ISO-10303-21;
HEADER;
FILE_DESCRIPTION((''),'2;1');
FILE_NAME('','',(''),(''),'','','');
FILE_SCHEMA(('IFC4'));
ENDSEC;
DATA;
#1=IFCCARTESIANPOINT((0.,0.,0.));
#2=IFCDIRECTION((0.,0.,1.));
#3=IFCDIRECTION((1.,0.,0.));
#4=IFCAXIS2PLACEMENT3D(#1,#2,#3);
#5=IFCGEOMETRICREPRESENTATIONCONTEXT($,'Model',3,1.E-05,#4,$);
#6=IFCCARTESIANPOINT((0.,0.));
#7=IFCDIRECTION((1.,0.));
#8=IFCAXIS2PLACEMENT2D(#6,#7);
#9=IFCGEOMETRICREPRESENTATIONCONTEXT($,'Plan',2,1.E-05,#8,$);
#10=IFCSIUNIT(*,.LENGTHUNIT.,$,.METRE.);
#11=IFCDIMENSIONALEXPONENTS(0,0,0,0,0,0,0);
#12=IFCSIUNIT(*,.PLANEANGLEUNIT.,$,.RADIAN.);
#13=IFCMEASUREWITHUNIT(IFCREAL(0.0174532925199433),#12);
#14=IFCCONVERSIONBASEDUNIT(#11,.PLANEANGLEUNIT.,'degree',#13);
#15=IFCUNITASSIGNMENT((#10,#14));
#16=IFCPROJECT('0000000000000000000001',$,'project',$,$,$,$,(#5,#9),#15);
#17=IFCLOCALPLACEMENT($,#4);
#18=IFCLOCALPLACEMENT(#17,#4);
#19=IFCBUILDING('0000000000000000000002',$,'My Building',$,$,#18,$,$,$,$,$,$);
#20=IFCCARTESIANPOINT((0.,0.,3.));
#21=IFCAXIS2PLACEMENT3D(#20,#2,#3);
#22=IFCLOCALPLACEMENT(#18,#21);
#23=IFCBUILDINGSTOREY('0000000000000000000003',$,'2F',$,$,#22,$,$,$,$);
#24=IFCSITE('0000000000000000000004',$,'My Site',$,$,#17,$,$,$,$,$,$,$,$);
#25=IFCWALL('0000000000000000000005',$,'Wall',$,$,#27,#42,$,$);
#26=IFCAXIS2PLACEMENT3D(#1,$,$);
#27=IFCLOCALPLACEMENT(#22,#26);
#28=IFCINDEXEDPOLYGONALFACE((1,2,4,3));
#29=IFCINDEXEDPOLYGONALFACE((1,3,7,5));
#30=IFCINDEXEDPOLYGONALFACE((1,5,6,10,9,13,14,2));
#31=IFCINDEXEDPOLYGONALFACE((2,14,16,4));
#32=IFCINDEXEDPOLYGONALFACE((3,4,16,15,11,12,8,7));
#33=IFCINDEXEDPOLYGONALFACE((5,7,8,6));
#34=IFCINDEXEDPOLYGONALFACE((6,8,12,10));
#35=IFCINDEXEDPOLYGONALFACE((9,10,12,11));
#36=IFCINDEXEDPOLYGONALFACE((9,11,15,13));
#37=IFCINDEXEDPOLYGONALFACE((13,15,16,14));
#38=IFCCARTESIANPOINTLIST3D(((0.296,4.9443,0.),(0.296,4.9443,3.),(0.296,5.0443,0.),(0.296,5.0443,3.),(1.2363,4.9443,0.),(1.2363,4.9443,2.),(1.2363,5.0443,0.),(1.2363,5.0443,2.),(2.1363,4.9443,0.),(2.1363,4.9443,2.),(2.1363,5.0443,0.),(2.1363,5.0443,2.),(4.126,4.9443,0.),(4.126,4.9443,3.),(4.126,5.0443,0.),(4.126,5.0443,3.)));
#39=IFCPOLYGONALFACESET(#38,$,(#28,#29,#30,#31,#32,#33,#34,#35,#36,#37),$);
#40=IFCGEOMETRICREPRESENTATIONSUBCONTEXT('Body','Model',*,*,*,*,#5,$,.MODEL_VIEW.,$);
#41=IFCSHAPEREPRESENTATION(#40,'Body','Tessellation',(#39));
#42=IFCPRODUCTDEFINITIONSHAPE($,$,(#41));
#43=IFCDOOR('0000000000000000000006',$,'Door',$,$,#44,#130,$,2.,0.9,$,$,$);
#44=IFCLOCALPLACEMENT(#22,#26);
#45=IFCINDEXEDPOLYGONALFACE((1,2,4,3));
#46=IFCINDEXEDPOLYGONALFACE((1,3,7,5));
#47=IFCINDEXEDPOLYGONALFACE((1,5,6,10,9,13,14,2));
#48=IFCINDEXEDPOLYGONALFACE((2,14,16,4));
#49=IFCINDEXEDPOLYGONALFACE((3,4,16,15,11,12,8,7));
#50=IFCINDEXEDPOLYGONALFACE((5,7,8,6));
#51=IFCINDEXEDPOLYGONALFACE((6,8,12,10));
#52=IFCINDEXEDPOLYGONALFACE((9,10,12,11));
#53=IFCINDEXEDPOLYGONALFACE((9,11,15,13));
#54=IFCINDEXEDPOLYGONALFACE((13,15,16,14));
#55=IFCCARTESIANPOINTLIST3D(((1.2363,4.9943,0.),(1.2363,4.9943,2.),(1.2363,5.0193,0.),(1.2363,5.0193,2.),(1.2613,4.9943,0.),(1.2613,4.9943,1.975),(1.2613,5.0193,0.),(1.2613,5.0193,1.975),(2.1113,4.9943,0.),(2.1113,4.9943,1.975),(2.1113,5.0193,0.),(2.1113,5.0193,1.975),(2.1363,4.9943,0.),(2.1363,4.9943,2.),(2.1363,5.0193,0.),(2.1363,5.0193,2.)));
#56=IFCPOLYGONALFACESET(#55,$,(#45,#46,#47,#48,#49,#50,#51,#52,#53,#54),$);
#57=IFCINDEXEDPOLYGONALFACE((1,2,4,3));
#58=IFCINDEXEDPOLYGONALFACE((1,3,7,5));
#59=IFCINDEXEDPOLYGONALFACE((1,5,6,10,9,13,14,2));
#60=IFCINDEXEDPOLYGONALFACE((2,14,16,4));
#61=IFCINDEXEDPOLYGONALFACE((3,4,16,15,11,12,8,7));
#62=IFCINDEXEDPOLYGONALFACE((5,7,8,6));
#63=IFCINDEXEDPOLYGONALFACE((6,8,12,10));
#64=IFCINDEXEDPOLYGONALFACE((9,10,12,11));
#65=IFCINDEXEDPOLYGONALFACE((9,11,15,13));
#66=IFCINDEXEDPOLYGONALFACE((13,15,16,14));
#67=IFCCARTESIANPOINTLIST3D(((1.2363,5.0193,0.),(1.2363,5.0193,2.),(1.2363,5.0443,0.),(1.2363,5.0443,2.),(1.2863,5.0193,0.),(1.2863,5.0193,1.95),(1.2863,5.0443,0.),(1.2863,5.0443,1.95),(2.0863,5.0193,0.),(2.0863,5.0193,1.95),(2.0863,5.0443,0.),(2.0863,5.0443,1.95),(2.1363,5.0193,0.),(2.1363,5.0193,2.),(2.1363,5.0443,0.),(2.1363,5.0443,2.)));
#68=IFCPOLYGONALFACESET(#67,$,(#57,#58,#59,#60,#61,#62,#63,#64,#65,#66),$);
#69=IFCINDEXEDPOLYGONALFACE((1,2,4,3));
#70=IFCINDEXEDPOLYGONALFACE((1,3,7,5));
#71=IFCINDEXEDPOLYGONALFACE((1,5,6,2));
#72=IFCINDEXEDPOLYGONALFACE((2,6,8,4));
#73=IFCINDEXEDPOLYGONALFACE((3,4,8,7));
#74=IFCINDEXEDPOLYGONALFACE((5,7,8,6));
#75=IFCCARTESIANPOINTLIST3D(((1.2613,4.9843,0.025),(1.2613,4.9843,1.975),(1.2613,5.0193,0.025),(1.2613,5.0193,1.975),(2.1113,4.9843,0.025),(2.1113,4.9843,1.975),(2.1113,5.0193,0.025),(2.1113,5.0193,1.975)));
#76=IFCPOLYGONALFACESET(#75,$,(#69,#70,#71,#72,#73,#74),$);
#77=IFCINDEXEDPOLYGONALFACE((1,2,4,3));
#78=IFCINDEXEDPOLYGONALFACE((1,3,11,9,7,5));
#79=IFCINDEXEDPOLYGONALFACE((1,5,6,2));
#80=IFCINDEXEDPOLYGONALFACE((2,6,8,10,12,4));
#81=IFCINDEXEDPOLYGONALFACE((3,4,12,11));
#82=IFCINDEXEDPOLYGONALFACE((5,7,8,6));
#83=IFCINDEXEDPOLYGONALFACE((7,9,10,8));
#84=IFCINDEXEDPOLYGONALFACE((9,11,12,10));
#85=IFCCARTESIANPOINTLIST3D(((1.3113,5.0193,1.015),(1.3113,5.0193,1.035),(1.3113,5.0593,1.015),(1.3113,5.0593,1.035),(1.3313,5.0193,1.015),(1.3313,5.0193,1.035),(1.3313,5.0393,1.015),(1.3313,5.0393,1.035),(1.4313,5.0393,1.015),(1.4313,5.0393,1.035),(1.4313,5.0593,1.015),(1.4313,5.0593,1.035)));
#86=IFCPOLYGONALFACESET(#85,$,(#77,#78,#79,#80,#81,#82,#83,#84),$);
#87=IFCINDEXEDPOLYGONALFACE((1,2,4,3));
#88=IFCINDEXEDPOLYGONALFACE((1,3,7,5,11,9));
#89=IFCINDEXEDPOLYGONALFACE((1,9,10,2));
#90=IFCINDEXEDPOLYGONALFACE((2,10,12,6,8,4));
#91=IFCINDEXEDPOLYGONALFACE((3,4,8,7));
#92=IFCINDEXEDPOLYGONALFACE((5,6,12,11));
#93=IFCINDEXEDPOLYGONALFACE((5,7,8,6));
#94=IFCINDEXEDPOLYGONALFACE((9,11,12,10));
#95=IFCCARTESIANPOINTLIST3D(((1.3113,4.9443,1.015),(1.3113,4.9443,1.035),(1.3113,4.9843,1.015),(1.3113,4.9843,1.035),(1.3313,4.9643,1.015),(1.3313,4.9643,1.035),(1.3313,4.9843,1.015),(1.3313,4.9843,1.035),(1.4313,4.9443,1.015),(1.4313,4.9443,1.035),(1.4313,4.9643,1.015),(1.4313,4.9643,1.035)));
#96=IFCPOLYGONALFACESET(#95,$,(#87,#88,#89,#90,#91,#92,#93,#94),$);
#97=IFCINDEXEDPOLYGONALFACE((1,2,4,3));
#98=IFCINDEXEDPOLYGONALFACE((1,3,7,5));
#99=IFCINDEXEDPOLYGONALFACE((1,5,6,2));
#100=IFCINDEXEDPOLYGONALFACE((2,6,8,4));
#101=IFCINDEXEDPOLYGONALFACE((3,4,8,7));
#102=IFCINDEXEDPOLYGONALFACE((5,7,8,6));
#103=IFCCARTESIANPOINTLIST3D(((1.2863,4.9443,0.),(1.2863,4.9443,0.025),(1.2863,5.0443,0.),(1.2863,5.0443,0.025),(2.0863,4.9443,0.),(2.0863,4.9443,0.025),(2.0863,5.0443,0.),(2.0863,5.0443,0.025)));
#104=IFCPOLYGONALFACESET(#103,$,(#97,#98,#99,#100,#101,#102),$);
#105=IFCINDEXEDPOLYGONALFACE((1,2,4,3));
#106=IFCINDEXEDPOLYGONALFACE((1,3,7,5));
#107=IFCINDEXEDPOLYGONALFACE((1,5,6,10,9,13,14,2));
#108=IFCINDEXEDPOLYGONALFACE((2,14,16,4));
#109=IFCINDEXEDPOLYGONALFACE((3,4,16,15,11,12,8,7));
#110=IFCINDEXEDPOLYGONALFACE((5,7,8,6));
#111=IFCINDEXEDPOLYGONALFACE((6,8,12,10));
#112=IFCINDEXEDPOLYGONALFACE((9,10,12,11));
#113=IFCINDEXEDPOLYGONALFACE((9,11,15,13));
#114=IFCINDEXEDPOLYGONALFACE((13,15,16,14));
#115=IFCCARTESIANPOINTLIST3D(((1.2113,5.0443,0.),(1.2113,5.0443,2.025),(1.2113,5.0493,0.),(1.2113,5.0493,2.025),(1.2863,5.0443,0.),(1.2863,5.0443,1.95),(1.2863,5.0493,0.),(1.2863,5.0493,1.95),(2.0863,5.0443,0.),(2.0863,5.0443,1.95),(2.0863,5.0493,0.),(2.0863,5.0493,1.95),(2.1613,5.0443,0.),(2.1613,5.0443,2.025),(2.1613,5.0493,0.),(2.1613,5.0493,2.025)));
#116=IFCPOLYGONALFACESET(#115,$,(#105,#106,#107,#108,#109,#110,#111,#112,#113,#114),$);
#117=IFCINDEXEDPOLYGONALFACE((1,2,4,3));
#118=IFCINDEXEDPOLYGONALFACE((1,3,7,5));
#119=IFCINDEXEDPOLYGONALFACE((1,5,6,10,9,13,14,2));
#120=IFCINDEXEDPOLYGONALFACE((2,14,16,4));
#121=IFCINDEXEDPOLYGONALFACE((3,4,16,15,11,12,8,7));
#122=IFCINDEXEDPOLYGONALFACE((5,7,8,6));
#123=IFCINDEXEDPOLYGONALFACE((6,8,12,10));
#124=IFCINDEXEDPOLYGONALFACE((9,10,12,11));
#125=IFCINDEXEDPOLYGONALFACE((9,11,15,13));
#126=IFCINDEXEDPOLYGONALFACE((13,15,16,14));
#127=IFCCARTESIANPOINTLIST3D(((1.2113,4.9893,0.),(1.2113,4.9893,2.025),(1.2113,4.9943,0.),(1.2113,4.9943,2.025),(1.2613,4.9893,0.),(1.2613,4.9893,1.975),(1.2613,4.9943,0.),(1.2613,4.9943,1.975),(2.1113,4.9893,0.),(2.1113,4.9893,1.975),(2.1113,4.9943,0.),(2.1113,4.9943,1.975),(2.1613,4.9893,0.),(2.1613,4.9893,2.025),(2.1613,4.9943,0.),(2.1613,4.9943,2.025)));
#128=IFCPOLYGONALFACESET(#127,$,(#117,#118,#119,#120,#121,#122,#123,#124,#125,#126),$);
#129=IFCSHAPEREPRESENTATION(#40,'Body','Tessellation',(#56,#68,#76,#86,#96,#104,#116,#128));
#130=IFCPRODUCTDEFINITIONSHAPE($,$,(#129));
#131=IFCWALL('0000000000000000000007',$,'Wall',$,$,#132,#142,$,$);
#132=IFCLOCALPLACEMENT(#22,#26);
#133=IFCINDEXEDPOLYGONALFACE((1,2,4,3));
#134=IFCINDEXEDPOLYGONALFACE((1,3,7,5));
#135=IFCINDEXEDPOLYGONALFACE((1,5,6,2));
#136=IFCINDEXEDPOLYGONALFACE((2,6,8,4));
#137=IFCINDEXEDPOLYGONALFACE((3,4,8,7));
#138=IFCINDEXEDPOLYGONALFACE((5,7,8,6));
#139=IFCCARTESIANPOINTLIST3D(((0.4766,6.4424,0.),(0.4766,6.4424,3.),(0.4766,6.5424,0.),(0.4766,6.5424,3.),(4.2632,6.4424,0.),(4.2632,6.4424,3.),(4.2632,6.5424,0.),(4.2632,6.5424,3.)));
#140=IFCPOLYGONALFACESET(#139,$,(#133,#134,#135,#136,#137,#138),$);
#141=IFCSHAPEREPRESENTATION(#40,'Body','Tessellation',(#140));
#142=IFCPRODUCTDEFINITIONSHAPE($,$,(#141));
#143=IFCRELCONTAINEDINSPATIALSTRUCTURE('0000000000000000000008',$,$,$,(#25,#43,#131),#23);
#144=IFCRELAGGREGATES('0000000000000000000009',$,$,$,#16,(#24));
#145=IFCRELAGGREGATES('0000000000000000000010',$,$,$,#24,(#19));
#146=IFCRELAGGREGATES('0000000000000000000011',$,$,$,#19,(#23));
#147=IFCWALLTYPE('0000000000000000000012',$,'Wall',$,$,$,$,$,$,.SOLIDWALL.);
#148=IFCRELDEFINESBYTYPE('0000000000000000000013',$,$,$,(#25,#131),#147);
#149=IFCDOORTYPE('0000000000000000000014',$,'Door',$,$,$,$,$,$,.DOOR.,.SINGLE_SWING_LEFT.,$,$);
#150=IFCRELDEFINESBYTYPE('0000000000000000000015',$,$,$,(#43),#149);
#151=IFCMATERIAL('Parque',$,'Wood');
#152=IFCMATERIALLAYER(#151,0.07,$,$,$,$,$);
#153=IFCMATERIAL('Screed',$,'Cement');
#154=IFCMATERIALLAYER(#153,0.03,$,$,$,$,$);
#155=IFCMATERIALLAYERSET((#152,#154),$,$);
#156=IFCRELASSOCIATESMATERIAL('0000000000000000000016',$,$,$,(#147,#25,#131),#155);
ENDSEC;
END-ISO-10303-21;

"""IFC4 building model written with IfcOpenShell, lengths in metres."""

from ifc_helpers import new_model, entity, si_unit, converted_unit, frame, origin_with_axes, origin_2d_with_axis, place, context, subcontext, project, spatial, line, indexed_curve, outline, extrude, shape, source, transform, mapped, material, layer, layer_set, layer_usage, type_object, type_shapes, element, fill, save


model = new_model("IFC4")

# Units and contexts
model_context = context("Model", 3, precision=1e-05, world=origin_with_axes())
plan_context = context("Plan", 2, precision=1e-05, world=origin_2d_with_axis())
body_context_1 = subcontext(model_context, "Body", "Model", "MODEL_VIEW")
body_context_2 = subcontext(plan_context, "Body", "Plan", "PLAN_VIEW")
ifc_project = project(units=[si_unit("LENGTHUNIT", "METRE"), converted_unit("PLANEANGLEUNIT", "degree", entity("IfcReal", 0.0174532925199433), si_unit("PLANEANGLEUNIT", "RADIAN"), dimensions=[0, 0, 0, 0, 0, 0, 0])], contexts=[model_context, plan_context])

# Site, building, storey
site_placement = place(None, origin_with_axes())
site = spatial("IfcSite", under=ifc_project, at=site_placement, Name="My Site")
building_placement = place(site_placement, origin_with_axes())
building = spatial("IfcBuilding", under=site, at=building_placement, Name="My Building")
storey_placement = place(building_placement, frame((0.0, 0.0, 3.0), z_axis=(0.0, 0.0, 1.0), x_axis=(1.0, 0.0, 0.0)))
storey = spatial("IfcBuildingStorey", under=building, at=storey_placement, Name="2F")

# Shared definitions
ifc_material_1 = material(Name="Parque", Category="Wood")
ifc_layer_1 = layer(ifc_material_1, 0.07)
ifc_material_2 = material(Name="Screed", Category="Cement")
ifc_layer_2 = layer(ifc_material_2, 0.03)
ifc_layer_set = layer_set([ifc_layer_1, ifc_layer_2])
wall_type = type_object("IfcWallType", Name="Wall", PredefinedType="SOLIDWALL", material=ifc_layer_set)

# Wall, opening, door
shared_shape_1 = source(origin_with_axes(), body_context_1, "Body", "SweptSolid", [
    extrude(outline(indexed_curve([(0.0, 0.0), (0.9, 0.0), (0.9, 2.0), (0.0, 2.0)], segments=[line(1, 2, 3, 4, 1)])), frame((0.0, -0.6, 0.0), z_axis=(0.0, -1.0, 0.0), x_axis=(1.0, 0.0, 0.0)), (0.0, 0.0, -1.0), 1.2),
])
door_type = type_object("IfcDoorType", Name="Door", OperationType="SINGLE_SWING_LEFT", PredefinedType="DOOR")
shared_shape_2 = source(origin_with_axes(), body_context_1, "Body", "SweptSolid", [
    extrude(outline(indexed_curve([(0.0, 0.0), (0.0, 2.0), (0.9, 2.0), (0.9, 0.0), (0.875, 0.0), (0.875, 1.975), (0.025, 1.975), (0.025, 0.0)], segments=[line(1, 2, 3, 4, 5, 6, 7, 8, 1)])), frame((0.0, 0.025, 0.0), z_axis=(0.0, -1.0, 0.0), x_axis=(1.0, 0.0, 0.0)), (0.0, 0.0, -1.0), 0.025),
    extrude(outline(indexed_curve([(0.0, 0.0), (0.0, 2.0), (0.9, 2.0), (0.9, 0.0), (0.85, 0.0), (0.85, 1.95), (0.05, 1.95), (0.05, 0.0)], segments=[line(1, 2, 3, 4, 5, 6, 7, 8, 1)])), frame((0.0, 0.0, 0.0), z_axis=(0.0, -1.0, 0.0), x_axis=(1.0, 0.0, 0.0)), (0.0, 0.0, -1.0), 0.025),
    extrude(outline(indexed_curve([(0.0, 0.0), (0.85, 0.0), (0.85, 0.035), (0.0, 0.035)], segments=[line(1, 2, 3, 4, 1)])), frame((0.025, 0.025, 0.025), z_axis=(0.0, 0.0, 1.0), x_axis=(1.0, 0.0, 0.0)), (0.0, 0.0, 1.0), 1.95),
    extrude(outline(indexed_curve([(0.0, 0.0), (0.0, -0.04), (-0.12, -0.04), (-0.12, -0.02), (-0.02, -0.02), (-0.02, 0.0)], segments=[line(1, 2, 3, 4, 5, 6, 1)])), frame((0.825, 0.025, 1.015), z_axis=(0.0, 0.0, 1.0), x_axis=(1.0, 0.0, 0.0)), (0.0, 0.0, 1.0), 0.02),
    extrude(outline(indexed_curve([(0.0, 0.0), (0.0, 0.04), (-0.12, 0.04), (-0.12, 0.02), (-0.02, 0.02), (-0.02, 0.0)], segments=[line(1, 2, 3, 4, 5, 6, 1)])), frame((0.825, 0.06, 1.015), z_axis=(0.0, 0.0, 1.0), x_axis=(1.0, 0.0, 0.0)), (0.0, 0.0, 1.0), 0.02),
    extrude(outline(indexed_curve([(0.0, 0.0), (0.8, 0.0), (0.8, 0.1), (0.0, 0.1)], segments=[line(1, 2, 3, 4, 1)])), frame((0.05, 0.0, 0.0), z_axis=(0.0, 0.0, 1.0), x_axis=(1.0, 0.0, 0.0)), (0.0, 0.0, 1.0), 0.025),
    extrude(outline(indexed_curve([(0.0, 0.0), (0.0, 2.025), (0.95, 2.025), (0.95, 0.0), (0.875, 0.0), (0.875, 1.95), (0.075, 1.95), (0.075, 0.0)], segments=[line(1, 2, 3, 4, 5, 6, 7, 8, 1)])), frame((-0.025, -0.005, 0.0), z_axis=(0.0, -1.0, 0.0), x_axis=(1.0, 0.0, 0.0)), (0.0, 0.0, -1.0), 0.005),
    extrude(outline(indexed_curve([(0.0, 0.0), (0.0, 2.025), (0.95, 2.025), (0.95, 0.0), (0.9, 0.0), (0.9, 1.975), (0.05, 1.975), (0.05, 0.0)], segments=[line(1, 2, 3, 4, 5, 6, 7, 8, 1)])), frame((-0.025, 0.05, 0.0), z_axis=(0.0, -1.0, 0.0), x_axis=(1.0, 0.0, 0.0)), (0.0, 0.0, -1.0), 0.005),
])
shared_shape_3 = source(origin_with_axes(), body_context_2, "Body", "Curve2D", [
    entity("IfcIndexedPolyCurve", entity("IfcCartesianPointList2D", [[0.0, 0.0], [0.0, 0.05], [0.025, 0.05], [0.025, 0.025], [0.05, 0.025], [0.05, 0.0]]), [entity("IfcLineIndex", [1, 2, 3, 4, 5, 6, 1])]),
    entity("IfcIndexedPolyCurve", entity("IfcCartesianPointList2D", [[0.9, 0.0], [0.9, 0.05], [0.875, 0.05], [0.875, 0.025], [0.85, 0.025], [0.85, 0.0]]), [entity("IfcLineIndex", [1, 2, 3, 4, 5, 6, 1])]),
    entity("IfcTrimmedCurve", entity("IfcEllipse", entity("IfcAxis2Placement2D", entity("IfcCartesianPoint", [0.06, 0.05]), entity("IfcDirection", [1.0, 0.0])), 0.815, 0.85), [entity("IfcCartesianPoint", [0.875, 0.05])], [entity("IfcCartesianPoint", [0.06, 0.9])], True, "CARTESIAN"),
    entity("IfcIndexedPolyCurve", entity("IfcCartesianPointList2D", [[0.025, 0.05], [0.06, 0.05], [0.06, 0.9], [0.025, 0.9]]), [entity("IfcLineIndex", [1, 2, 3, 4, 1])]),
])
type_shapes(door_type, [shared_shape_2, shared_shape_3])
ifc_layer_usage_1 = layer_usage(ifc_layer_set, "AXIS2", "POSITIVE", 0.0)
wall_1_placement = place(storey_placement, frame((4.126, 5.0443, 0.0), z_axis=(0.0, 0.0, 1.0), x_axis=(-1.0, -0.000001, 0.0)))
wall_1 = element("IfcWall", 1, at=wall_1_placement, inside=storey, type_object=wall_type, material=ifc_layer_usage_1, Name="Wall", context=body_context_1, shape_type="SweptSolid", body=[
    extrude(outline(indexed_curve([(0.0, 0.0), (0.0, 0.1), (3.83, 0.1), (3.83, 0.0)], segments=[line(1, 2, 3, 4, 1)])), origin_with_axes(), (0.0, 0.0, 1.0), 3.0),
])
opening_1_placement = place(wall_1_placement, frame((1.9897, 0.0, 0.0), z_axis=(0.0, 0.0, 1.0), x_axis=(1.0, 0.0, 0.0)))
opening_1 = element("IfcOpeningElement", 2, at=opening_1_placement, cuts=wall_1, PredefinedType="OPENING", context=body_context_1, shape_type="MappedRepresentation", body=[
    mapped(shared_shape_1, transform((0.0, 0.0, 0.0), x_axis=(1.0, 0.0, 0.0), y_axis=(0.0, 1.0, 0.0), z_axis=(0.0, 0.0, 1.0), scale=1.0)),
])
door_1_placement = place(opening_1_placement, origin_with_axes())
door_1 = element("IfcDoor", 3, at=door_1_placement, inside=storey, type_object=door_type, Name="Door", OverallHeight=2.0, OverallWidth=0.9, shapes=[
    shape(body_context_1, "Body", "MappedRepresentation", [mapped(shared_shape_2, transform((0.0, 0.0, 0.0), x_axis=(1.0, 0.0, 0.0), y_axis=(0.0, 1.0, 0.0), z_axis=(0.0, 0.0, 1.0), scale=1.0))]),
    shape(body_context_2, "Body", "MappedRepresentation", [mapped(shared_shape_3, transform((0.0, 0.0, 0.0), x_axis=(1.0, 0.0, 0.0), y_axis=(0.0, 1.0, 0.0), z_axis=(0.0, 0.0, 1.0), scale=1.0))]),
])
fill(opening_1, door_1)

# Wall
ifc_layer_usage_2 = layer_usage(ifc_layer_set, "AXIS2", "POSITIVE", 0.0)
wall_2_placement = place(storey_placement, frame((4.2632, 6.5424, 0.0), z_axis=(0.0, 0.0, 1.0), x_axis=(-1.0, 0.0, 0.0)))
element("IfcWall", 4, at=wall_2_placement, inside=storey, type_object=wall_type, material=ifc_layer_usage_2, Name="Wall", context=body_context_1, shape_type="SweptSolid", body=[
    extrude(outline(indexed_curve([(0.0, 0.0), (0.0, 0.1), (3.7865, 0.1), (3.7865, 0.0)], segments=[line(1, 2, 3, 4, 1)])), origin_with_axes(), (0.0, 0.0, 1.0), 3.0),
])

save(model, "model.ifc")
